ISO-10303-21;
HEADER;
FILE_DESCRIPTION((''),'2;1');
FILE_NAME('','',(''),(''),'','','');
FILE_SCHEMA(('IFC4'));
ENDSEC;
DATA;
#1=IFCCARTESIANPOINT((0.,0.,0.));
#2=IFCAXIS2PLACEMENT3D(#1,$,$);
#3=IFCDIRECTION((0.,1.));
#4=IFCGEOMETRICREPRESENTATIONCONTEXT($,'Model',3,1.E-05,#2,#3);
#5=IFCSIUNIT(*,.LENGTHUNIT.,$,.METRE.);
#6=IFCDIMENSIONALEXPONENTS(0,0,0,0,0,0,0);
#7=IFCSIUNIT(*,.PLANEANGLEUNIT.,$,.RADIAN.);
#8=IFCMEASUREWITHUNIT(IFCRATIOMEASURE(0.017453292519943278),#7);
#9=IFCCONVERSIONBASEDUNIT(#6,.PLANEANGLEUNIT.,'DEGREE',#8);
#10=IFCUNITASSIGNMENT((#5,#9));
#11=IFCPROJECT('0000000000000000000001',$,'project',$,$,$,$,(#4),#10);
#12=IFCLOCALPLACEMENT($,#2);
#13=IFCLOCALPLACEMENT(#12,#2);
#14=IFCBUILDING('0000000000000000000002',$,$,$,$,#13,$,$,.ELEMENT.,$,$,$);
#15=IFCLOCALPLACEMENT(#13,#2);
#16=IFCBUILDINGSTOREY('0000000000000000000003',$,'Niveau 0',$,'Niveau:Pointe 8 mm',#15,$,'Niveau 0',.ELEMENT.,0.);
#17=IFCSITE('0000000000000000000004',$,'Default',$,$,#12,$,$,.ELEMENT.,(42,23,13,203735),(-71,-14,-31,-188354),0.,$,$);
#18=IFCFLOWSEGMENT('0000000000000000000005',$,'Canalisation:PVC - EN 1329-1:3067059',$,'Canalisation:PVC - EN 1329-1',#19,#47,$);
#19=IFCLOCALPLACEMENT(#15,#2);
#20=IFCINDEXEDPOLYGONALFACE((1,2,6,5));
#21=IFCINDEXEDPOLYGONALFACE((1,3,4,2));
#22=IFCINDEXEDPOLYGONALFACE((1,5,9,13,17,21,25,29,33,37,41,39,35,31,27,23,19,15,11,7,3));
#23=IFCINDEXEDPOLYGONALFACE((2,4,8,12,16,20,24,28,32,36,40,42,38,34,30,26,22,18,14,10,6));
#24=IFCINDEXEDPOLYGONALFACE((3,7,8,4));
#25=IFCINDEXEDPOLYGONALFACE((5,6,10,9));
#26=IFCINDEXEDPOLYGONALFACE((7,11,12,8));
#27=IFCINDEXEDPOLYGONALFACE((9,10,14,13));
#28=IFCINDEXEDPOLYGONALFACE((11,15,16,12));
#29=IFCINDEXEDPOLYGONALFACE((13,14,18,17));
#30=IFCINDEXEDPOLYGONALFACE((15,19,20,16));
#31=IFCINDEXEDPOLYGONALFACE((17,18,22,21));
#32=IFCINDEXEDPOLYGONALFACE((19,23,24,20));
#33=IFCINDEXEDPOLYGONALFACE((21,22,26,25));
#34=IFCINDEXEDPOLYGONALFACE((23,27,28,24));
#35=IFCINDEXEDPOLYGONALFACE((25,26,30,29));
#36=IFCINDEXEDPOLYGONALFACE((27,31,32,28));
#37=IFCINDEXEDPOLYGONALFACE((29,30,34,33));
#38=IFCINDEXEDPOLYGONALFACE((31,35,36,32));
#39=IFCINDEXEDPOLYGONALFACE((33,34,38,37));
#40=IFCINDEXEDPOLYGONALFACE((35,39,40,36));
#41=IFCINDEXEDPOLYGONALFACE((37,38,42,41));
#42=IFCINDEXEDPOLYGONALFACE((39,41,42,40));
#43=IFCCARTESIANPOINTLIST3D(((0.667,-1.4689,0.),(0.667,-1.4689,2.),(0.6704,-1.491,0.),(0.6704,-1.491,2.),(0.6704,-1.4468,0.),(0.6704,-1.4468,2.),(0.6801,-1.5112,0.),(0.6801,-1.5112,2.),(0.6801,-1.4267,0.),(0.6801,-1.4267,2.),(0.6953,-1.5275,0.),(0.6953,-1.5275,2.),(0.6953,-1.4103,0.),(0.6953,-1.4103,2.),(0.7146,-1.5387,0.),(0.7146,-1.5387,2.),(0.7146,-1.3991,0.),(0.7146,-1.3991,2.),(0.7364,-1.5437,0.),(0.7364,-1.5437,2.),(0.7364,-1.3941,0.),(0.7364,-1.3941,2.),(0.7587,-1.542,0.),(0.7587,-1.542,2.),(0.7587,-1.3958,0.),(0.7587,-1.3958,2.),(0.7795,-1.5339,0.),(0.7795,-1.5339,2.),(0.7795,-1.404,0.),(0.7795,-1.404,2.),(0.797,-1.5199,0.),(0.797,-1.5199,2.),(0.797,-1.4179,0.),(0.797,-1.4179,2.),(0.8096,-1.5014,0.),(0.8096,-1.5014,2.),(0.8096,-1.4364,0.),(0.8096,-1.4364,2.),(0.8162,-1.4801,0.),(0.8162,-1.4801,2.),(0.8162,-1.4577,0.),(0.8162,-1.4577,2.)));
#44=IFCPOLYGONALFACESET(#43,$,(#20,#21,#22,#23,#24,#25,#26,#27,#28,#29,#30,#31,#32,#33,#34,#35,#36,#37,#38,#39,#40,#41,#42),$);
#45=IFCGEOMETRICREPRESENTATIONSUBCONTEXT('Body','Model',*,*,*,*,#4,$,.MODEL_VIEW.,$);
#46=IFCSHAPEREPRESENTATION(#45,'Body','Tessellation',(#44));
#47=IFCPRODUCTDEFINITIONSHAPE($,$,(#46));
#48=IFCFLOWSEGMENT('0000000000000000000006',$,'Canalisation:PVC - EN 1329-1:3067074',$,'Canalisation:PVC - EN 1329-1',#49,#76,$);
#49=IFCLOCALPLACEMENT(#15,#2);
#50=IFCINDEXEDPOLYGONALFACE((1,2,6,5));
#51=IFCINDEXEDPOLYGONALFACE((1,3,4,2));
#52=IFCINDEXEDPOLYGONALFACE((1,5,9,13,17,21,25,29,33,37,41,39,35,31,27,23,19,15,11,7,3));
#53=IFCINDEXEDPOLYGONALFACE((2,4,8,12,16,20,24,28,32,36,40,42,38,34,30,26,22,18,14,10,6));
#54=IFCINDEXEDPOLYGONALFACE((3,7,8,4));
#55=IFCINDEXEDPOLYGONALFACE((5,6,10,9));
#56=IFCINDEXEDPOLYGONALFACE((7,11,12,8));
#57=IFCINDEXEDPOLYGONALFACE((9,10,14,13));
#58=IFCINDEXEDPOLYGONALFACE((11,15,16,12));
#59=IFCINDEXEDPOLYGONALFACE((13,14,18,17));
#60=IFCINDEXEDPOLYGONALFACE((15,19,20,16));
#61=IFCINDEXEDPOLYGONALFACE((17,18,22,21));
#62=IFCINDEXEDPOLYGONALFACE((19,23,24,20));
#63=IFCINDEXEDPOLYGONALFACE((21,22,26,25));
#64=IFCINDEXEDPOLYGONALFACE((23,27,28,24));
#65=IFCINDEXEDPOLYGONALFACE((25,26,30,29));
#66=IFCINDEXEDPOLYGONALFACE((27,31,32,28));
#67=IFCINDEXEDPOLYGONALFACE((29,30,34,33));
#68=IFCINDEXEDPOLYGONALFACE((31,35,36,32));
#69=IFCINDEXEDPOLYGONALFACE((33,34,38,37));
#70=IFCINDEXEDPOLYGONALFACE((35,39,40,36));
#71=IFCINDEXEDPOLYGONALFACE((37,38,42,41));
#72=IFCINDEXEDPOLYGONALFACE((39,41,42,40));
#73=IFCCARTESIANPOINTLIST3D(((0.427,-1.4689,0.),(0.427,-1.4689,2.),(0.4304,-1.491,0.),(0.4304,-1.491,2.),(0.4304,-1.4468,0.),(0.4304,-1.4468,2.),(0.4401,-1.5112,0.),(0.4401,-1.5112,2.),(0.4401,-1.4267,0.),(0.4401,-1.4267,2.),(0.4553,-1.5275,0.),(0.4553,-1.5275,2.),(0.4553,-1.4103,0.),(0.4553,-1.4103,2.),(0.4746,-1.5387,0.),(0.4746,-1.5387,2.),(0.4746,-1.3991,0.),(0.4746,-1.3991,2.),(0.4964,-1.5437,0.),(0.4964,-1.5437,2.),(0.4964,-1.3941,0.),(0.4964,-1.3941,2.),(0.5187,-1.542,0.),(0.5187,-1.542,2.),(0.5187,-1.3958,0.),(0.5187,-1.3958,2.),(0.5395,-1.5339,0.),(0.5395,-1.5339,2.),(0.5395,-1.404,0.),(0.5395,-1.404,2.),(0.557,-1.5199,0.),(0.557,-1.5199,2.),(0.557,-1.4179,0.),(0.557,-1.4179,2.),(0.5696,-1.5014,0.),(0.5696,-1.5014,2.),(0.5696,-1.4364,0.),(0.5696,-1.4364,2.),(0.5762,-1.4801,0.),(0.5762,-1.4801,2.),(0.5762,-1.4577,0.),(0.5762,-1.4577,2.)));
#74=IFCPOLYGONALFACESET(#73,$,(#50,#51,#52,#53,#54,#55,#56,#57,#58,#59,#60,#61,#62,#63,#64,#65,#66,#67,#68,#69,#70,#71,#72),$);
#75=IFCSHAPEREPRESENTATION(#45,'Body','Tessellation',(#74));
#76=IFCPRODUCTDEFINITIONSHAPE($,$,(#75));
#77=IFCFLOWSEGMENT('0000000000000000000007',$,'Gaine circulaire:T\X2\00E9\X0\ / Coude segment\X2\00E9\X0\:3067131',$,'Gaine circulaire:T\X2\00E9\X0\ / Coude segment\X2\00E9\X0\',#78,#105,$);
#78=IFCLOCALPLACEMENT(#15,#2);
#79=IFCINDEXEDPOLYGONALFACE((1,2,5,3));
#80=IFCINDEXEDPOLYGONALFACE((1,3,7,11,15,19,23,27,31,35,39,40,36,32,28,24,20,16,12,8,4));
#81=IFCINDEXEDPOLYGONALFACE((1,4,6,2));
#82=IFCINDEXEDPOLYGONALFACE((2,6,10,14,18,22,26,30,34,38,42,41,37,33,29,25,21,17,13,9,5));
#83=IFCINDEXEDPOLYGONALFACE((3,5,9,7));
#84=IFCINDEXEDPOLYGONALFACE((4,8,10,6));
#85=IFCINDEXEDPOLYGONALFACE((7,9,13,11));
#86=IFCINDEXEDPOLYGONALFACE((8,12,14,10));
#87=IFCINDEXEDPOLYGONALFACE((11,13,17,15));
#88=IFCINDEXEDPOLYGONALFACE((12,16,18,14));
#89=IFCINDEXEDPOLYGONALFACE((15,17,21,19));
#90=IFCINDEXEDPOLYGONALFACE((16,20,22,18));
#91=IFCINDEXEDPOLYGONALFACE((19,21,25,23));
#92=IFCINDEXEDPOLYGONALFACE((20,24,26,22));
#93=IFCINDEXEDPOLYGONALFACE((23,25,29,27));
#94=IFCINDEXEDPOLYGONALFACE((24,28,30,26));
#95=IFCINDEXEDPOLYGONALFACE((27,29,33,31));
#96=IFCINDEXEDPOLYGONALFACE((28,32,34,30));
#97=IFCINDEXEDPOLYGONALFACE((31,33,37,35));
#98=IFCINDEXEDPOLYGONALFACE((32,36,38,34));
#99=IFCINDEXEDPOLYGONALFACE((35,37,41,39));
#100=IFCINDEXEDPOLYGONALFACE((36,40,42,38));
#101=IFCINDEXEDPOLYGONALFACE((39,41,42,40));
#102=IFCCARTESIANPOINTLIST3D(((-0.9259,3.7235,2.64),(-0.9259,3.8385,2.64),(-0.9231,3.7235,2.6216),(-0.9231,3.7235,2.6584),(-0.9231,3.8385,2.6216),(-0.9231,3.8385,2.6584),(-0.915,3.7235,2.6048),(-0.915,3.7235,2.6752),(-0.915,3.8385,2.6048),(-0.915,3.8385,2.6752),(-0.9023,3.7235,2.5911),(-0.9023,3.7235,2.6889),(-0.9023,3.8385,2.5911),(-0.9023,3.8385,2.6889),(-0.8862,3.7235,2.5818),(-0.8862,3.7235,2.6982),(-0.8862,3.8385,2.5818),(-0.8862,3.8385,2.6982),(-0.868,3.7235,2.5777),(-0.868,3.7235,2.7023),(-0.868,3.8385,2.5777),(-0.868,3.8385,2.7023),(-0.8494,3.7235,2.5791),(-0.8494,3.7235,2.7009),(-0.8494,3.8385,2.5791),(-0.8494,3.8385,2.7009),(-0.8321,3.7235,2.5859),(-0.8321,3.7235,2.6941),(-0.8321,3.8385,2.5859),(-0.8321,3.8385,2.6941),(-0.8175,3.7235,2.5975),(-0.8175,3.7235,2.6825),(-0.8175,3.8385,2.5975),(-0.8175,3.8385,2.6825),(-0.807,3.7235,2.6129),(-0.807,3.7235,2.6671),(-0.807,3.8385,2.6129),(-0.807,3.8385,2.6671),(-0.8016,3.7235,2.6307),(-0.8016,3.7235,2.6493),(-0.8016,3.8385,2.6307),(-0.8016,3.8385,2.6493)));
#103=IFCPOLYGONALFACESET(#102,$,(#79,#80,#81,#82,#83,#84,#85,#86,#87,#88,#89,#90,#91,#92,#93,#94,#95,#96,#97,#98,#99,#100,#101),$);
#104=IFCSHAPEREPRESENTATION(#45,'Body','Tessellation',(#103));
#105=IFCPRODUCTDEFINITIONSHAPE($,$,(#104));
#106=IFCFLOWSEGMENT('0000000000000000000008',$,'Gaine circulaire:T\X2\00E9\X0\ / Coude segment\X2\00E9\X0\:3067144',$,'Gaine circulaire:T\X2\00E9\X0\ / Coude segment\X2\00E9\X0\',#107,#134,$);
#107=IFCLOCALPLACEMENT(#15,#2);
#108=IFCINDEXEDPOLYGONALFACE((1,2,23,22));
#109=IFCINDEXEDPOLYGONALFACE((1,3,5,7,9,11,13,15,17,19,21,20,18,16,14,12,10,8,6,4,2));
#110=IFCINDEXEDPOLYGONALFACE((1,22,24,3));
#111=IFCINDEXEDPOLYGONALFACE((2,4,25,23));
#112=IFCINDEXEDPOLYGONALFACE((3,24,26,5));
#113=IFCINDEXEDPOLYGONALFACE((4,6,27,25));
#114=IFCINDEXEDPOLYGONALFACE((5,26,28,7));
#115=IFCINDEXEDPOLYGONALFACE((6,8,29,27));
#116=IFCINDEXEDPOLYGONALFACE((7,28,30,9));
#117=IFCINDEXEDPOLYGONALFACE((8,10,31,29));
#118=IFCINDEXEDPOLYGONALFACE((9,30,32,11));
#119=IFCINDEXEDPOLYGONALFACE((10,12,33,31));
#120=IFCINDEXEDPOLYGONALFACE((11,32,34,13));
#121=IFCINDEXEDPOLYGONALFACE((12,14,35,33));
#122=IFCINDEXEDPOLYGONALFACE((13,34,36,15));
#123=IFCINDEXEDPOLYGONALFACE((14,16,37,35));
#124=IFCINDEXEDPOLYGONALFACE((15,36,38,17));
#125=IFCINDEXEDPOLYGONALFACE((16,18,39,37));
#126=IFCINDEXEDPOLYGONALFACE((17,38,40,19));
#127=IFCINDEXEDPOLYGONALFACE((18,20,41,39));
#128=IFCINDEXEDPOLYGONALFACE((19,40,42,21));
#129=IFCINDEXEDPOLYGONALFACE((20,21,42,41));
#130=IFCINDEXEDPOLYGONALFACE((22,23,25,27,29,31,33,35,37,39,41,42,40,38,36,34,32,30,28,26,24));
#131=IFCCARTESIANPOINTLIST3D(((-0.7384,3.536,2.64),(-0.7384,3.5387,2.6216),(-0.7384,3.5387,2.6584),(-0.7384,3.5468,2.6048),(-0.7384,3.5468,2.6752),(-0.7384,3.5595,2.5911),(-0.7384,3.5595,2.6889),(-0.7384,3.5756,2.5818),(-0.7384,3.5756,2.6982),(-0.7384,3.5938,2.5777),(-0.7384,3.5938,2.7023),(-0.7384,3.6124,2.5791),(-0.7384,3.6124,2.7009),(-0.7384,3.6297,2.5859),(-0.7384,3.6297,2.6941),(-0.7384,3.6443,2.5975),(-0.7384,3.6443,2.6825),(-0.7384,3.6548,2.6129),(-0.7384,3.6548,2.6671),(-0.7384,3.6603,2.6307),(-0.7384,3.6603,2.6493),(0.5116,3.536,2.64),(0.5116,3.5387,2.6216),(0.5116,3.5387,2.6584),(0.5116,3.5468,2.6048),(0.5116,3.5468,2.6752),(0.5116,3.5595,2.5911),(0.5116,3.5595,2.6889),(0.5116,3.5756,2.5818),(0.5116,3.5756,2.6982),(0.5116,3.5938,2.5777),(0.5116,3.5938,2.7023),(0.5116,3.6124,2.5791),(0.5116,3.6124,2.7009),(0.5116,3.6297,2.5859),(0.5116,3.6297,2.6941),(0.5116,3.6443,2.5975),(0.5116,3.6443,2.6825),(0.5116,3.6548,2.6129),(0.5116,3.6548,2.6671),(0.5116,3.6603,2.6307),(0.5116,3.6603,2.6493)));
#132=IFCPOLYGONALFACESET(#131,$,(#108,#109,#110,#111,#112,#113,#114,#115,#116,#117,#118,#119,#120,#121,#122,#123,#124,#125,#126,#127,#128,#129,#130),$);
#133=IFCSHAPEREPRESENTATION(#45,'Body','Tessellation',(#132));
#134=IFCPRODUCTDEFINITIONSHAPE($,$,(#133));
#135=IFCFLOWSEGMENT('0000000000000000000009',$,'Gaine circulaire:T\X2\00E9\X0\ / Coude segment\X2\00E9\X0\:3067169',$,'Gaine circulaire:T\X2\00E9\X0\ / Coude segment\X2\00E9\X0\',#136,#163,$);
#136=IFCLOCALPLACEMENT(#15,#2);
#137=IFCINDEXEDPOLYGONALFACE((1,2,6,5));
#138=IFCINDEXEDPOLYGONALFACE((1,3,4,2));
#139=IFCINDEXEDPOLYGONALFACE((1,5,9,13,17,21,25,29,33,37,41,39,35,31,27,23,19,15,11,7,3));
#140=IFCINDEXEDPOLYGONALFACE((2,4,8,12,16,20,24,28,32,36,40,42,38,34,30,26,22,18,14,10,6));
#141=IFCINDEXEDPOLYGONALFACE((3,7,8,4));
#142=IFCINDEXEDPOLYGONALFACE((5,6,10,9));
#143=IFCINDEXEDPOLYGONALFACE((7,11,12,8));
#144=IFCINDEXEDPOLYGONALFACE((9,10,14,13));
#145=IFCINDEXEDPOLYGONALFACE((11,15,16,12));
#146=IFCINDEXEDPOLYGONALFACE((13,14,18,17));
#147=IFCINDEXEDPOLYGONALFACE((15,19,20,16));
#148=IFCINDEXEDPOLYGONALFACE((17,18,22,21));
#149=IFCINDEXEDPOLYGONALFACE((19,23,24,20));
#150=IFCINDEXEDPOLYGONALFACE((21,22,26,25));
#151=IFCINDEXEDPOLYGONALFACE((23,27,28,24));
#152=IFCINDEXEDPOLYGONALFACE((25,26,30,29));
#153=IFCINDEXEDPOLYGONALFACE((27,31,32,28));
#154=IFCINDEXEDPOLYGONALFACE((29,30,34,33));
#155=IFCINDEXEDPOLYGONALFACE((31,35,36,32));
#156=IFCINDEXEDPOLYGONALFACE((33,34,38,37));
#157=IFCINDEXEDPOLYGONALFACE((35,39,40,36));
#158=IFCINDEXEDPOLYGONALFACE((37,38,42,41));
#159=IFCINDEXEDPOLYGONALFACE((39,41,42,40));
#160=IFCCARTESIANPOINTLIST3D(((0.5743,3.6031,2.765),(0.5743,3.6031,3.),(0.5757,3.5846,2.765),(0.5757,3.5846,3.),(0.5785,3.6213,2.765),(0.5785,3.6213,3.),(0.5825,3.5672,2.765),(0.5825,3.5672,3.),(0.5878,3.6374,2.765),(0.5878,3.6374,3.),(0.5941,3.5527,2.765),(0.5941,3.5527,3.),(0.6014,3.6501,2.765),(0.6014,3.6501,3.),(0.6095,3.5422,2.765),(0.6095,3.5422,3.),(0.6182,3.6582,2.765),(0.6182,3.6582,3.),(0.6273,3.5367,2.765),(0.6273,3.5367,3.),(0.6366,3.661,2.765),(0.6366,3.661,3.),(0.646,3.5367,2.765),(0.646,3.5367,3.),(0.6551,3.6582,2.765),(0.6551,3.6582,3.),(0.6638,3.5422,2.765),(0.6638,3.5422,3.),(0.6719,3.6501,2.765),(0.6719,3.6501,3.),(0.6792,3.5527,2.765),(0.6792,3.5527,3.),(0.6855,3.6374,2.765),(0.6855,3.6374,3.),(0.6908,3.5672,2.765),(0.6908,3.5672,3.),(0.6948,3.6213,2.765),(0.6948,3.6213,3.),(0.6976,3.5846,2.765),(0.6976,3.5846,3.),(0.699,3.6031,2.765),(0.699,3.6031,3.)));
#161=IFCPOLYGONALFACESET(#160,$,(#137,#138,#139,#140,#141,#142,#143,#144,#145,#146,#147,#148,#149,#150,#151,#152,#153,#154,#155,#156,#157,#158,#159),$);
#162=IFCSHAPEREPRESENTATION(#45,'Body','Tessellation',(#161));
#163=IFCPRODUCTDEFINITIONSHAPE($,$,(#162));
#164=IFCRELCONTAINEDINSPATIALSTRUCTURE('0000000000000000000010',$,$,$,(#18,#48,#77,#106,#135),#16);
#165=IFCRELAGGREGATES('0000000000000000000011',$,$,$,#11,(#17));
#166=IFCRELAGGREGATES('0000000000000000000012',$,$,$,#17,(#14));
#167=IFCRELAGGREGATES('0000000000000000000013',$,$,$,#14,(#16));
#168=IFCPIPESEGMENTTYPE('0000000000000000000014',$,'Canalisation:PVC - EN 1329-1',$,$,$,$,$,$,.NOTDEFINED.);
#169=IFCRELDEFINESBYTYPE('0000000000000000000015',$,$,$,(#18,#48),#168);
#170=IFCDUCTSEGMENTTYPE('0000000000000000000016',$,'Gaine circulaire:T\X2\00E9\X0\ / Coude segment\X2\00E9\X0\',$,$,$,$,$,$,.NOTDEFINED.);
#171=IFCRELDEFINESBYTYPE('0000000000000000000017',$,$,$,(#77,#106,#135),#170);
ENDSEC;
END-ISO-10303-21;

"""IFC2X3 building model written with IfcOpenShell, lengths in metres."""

from ifc_helpers import new_model, entity, si_unit, converted_unit, direction, frame, frame_2d, origin, origin_2d_with_axis, place, context, subcontext, project, spatial, circle, extrude, type_object, element, save


model = new_model("IFC2X3")

# Units and contexts
model_context = context("Model", 3, precision=1e-05, world=origin(), true_north=direction((0.0, 1.0)))
body_context = subcontext(model_context, "Body", "Model", "MODEL_VIEW")
ifc_project = project(units=[si_unit("LENGTHUNIT", "METRE"), converted_unit("PLANEANGLEUNIT", "DEGREE", entity("IfcRatioMeasure", 0.017453292519943278), si_unit("PLANEANGLEUNIT", "RADIAN"), dimensions=[0, 0, 0, 0, 0, 0, 0])], contexts=[model_context])

# Site, building, storey
site_placement = place(None, origin())
site = spatial("IfcSite", under=ifc_project, at=site_placement, Name="Default", CompositionType="ELEMENT", RefLatitude=(42, 23, 13, 203735), RefLongitude=(-71, -14, -31, -188354), RefElevation=0.0)
building_placement = place(site_placement, origin())
building = spatial("IfcBuilding", under=site, at=building_placement, CompositionType="ELEMENT")
storey_placement = place(building_placement, origin())
storey = spatial("IfcBuildingStorey", under=building, at=storey_placement, Name="Niveau 0", ObjectType="Niveau:Pointe 8 mm", LongName="Niveau 0", CompositionType="ELEMENT", Elevation=0.0)

# Flow segments
pipe_segment_type = type_object("IfcPipeSegmentType", Name="Canalisation:PVC - EN 1329-1", PredefinedType="NOTDEFINED")
flow_segment_1_placement = place(storey_placement, origin())
element("IfcFlowSegment", 1, at=flow_segment_1_placement, inside=storey, type_object=pipe_segment_type, Name="Canalisation:PVC - EN 1329-1:3067059", ObjectType="Canalisation:PVC - EN 1329-1", context=body_context, shape_type="SweptSolid", body=[
    extrude(circle(Radius=0.075, at=frame_2d((0.0, 0.0), x_axis=(1.0, 0.0))), frame((0.742, -1.4689, 0.0), z_axis=(0.0, 0.0, 1.0), x_axis=(-1.0, 0.0, 0.0)), (0.0, 0.0, 1.0), 2.0),
])
flow_segment_2_placement = place(storey_placement, origin())
element("IfcFlowSegment", 2, at=flow_segment_2_placement, inside=storey, type_object=pipe_segment_type, Name="Canalisation:PVC - EN 1329-1:3067074", ObjectType="Canalisation:PVC - EN 1329-1", context=body_context, shape_type="SweptSolid", body=[
    extrude(circle(Radius=0.075, at=frame_2d((0.0, 0.0), x_axis=(1.0, 0.0))), frame((0.502, -1.4689, 0.0), z_axis=(0.0, 0.0, 1.0), x_axis=(-1.0, 0.0, 0.0)), (0.0, 0.0, 1.0), 2.0),
])
duct_segment_type = type_object("IfcDuctSegmentType", Name="Gaine circulaire:Té / Coude segmenté", PredefinedType="NOTDEFINED")
flow_segment_3_placement = place(storey_placement, origin())
element("IfcFlowSegment", 3, at=flow_segment_3_placement, inside=storey, type_object=duct_segment_type, Name="Gaine circulaire:Té / Coude segmenté:3067131", ObjectType="Gaine circulaire:Té / Coude segmenté", context=body_context, shape_type="SweptSolid", body=[
    extrude(circle(Radius=0.0625, at=frame_2d((0.0, 0.0), x_axis=(1.0, 0.0))), frame((-0.8634, 3.7235, 2.64), z_axis=(0.0, 1.0, 0.0), x_axis=(-1.0, 0.0, 0.0)), (0.0, 0.0, 1.0), 0.115),
])
flow_segment_4_placement = place(storey_placement, origin())
element("IfcFlowSegment", 4, at=flow_segment_4_placement, inside=storey, type_object=duct_segment_type, Name="Gaine circulaire:Té / Coude segmenté:3067144", ObjectType="Gaine circulaire:Té / Coude segmenté", context=body_context, shape_type="SweptSolid", body=[
    extrude(circle(Radius=0.0625, at=origin_2d_with_axis()), frame((-0.7384, 3.5985, 2.64), z_axis=(1.0, 0.0, 0.0), x_axis=(0.0, -1.0, 0.0)), (0.0, 0.0, 1.0), 1.25),
])
flow_segment_5_placement = place(storey_placement, origin())
element("IfcFlowSegment", 5, at=flow_segment_5_placement, inside=storey, type_object=duct_segment_type, Name="Gaine circulaire:Té / Coude segmenté:3067169", ObjectType="Gaine circulaire:Té / Coude segmenté", context=body_context, shape_type="SweptSolid", body=[
    extrude(circle(Radius=0.0625, at=frame_2d((0.0, 0.0), x_axis=(1.0, 0.0))), frame((0.6366, 3.5985, 2.765), z_axis=(0.0, 0.0, 1.0), x_axis=(0.0, 1.0, 0.0)), (0.0, 0.0, 1.0), 0.235),
])

save(model, "model.ifc")
